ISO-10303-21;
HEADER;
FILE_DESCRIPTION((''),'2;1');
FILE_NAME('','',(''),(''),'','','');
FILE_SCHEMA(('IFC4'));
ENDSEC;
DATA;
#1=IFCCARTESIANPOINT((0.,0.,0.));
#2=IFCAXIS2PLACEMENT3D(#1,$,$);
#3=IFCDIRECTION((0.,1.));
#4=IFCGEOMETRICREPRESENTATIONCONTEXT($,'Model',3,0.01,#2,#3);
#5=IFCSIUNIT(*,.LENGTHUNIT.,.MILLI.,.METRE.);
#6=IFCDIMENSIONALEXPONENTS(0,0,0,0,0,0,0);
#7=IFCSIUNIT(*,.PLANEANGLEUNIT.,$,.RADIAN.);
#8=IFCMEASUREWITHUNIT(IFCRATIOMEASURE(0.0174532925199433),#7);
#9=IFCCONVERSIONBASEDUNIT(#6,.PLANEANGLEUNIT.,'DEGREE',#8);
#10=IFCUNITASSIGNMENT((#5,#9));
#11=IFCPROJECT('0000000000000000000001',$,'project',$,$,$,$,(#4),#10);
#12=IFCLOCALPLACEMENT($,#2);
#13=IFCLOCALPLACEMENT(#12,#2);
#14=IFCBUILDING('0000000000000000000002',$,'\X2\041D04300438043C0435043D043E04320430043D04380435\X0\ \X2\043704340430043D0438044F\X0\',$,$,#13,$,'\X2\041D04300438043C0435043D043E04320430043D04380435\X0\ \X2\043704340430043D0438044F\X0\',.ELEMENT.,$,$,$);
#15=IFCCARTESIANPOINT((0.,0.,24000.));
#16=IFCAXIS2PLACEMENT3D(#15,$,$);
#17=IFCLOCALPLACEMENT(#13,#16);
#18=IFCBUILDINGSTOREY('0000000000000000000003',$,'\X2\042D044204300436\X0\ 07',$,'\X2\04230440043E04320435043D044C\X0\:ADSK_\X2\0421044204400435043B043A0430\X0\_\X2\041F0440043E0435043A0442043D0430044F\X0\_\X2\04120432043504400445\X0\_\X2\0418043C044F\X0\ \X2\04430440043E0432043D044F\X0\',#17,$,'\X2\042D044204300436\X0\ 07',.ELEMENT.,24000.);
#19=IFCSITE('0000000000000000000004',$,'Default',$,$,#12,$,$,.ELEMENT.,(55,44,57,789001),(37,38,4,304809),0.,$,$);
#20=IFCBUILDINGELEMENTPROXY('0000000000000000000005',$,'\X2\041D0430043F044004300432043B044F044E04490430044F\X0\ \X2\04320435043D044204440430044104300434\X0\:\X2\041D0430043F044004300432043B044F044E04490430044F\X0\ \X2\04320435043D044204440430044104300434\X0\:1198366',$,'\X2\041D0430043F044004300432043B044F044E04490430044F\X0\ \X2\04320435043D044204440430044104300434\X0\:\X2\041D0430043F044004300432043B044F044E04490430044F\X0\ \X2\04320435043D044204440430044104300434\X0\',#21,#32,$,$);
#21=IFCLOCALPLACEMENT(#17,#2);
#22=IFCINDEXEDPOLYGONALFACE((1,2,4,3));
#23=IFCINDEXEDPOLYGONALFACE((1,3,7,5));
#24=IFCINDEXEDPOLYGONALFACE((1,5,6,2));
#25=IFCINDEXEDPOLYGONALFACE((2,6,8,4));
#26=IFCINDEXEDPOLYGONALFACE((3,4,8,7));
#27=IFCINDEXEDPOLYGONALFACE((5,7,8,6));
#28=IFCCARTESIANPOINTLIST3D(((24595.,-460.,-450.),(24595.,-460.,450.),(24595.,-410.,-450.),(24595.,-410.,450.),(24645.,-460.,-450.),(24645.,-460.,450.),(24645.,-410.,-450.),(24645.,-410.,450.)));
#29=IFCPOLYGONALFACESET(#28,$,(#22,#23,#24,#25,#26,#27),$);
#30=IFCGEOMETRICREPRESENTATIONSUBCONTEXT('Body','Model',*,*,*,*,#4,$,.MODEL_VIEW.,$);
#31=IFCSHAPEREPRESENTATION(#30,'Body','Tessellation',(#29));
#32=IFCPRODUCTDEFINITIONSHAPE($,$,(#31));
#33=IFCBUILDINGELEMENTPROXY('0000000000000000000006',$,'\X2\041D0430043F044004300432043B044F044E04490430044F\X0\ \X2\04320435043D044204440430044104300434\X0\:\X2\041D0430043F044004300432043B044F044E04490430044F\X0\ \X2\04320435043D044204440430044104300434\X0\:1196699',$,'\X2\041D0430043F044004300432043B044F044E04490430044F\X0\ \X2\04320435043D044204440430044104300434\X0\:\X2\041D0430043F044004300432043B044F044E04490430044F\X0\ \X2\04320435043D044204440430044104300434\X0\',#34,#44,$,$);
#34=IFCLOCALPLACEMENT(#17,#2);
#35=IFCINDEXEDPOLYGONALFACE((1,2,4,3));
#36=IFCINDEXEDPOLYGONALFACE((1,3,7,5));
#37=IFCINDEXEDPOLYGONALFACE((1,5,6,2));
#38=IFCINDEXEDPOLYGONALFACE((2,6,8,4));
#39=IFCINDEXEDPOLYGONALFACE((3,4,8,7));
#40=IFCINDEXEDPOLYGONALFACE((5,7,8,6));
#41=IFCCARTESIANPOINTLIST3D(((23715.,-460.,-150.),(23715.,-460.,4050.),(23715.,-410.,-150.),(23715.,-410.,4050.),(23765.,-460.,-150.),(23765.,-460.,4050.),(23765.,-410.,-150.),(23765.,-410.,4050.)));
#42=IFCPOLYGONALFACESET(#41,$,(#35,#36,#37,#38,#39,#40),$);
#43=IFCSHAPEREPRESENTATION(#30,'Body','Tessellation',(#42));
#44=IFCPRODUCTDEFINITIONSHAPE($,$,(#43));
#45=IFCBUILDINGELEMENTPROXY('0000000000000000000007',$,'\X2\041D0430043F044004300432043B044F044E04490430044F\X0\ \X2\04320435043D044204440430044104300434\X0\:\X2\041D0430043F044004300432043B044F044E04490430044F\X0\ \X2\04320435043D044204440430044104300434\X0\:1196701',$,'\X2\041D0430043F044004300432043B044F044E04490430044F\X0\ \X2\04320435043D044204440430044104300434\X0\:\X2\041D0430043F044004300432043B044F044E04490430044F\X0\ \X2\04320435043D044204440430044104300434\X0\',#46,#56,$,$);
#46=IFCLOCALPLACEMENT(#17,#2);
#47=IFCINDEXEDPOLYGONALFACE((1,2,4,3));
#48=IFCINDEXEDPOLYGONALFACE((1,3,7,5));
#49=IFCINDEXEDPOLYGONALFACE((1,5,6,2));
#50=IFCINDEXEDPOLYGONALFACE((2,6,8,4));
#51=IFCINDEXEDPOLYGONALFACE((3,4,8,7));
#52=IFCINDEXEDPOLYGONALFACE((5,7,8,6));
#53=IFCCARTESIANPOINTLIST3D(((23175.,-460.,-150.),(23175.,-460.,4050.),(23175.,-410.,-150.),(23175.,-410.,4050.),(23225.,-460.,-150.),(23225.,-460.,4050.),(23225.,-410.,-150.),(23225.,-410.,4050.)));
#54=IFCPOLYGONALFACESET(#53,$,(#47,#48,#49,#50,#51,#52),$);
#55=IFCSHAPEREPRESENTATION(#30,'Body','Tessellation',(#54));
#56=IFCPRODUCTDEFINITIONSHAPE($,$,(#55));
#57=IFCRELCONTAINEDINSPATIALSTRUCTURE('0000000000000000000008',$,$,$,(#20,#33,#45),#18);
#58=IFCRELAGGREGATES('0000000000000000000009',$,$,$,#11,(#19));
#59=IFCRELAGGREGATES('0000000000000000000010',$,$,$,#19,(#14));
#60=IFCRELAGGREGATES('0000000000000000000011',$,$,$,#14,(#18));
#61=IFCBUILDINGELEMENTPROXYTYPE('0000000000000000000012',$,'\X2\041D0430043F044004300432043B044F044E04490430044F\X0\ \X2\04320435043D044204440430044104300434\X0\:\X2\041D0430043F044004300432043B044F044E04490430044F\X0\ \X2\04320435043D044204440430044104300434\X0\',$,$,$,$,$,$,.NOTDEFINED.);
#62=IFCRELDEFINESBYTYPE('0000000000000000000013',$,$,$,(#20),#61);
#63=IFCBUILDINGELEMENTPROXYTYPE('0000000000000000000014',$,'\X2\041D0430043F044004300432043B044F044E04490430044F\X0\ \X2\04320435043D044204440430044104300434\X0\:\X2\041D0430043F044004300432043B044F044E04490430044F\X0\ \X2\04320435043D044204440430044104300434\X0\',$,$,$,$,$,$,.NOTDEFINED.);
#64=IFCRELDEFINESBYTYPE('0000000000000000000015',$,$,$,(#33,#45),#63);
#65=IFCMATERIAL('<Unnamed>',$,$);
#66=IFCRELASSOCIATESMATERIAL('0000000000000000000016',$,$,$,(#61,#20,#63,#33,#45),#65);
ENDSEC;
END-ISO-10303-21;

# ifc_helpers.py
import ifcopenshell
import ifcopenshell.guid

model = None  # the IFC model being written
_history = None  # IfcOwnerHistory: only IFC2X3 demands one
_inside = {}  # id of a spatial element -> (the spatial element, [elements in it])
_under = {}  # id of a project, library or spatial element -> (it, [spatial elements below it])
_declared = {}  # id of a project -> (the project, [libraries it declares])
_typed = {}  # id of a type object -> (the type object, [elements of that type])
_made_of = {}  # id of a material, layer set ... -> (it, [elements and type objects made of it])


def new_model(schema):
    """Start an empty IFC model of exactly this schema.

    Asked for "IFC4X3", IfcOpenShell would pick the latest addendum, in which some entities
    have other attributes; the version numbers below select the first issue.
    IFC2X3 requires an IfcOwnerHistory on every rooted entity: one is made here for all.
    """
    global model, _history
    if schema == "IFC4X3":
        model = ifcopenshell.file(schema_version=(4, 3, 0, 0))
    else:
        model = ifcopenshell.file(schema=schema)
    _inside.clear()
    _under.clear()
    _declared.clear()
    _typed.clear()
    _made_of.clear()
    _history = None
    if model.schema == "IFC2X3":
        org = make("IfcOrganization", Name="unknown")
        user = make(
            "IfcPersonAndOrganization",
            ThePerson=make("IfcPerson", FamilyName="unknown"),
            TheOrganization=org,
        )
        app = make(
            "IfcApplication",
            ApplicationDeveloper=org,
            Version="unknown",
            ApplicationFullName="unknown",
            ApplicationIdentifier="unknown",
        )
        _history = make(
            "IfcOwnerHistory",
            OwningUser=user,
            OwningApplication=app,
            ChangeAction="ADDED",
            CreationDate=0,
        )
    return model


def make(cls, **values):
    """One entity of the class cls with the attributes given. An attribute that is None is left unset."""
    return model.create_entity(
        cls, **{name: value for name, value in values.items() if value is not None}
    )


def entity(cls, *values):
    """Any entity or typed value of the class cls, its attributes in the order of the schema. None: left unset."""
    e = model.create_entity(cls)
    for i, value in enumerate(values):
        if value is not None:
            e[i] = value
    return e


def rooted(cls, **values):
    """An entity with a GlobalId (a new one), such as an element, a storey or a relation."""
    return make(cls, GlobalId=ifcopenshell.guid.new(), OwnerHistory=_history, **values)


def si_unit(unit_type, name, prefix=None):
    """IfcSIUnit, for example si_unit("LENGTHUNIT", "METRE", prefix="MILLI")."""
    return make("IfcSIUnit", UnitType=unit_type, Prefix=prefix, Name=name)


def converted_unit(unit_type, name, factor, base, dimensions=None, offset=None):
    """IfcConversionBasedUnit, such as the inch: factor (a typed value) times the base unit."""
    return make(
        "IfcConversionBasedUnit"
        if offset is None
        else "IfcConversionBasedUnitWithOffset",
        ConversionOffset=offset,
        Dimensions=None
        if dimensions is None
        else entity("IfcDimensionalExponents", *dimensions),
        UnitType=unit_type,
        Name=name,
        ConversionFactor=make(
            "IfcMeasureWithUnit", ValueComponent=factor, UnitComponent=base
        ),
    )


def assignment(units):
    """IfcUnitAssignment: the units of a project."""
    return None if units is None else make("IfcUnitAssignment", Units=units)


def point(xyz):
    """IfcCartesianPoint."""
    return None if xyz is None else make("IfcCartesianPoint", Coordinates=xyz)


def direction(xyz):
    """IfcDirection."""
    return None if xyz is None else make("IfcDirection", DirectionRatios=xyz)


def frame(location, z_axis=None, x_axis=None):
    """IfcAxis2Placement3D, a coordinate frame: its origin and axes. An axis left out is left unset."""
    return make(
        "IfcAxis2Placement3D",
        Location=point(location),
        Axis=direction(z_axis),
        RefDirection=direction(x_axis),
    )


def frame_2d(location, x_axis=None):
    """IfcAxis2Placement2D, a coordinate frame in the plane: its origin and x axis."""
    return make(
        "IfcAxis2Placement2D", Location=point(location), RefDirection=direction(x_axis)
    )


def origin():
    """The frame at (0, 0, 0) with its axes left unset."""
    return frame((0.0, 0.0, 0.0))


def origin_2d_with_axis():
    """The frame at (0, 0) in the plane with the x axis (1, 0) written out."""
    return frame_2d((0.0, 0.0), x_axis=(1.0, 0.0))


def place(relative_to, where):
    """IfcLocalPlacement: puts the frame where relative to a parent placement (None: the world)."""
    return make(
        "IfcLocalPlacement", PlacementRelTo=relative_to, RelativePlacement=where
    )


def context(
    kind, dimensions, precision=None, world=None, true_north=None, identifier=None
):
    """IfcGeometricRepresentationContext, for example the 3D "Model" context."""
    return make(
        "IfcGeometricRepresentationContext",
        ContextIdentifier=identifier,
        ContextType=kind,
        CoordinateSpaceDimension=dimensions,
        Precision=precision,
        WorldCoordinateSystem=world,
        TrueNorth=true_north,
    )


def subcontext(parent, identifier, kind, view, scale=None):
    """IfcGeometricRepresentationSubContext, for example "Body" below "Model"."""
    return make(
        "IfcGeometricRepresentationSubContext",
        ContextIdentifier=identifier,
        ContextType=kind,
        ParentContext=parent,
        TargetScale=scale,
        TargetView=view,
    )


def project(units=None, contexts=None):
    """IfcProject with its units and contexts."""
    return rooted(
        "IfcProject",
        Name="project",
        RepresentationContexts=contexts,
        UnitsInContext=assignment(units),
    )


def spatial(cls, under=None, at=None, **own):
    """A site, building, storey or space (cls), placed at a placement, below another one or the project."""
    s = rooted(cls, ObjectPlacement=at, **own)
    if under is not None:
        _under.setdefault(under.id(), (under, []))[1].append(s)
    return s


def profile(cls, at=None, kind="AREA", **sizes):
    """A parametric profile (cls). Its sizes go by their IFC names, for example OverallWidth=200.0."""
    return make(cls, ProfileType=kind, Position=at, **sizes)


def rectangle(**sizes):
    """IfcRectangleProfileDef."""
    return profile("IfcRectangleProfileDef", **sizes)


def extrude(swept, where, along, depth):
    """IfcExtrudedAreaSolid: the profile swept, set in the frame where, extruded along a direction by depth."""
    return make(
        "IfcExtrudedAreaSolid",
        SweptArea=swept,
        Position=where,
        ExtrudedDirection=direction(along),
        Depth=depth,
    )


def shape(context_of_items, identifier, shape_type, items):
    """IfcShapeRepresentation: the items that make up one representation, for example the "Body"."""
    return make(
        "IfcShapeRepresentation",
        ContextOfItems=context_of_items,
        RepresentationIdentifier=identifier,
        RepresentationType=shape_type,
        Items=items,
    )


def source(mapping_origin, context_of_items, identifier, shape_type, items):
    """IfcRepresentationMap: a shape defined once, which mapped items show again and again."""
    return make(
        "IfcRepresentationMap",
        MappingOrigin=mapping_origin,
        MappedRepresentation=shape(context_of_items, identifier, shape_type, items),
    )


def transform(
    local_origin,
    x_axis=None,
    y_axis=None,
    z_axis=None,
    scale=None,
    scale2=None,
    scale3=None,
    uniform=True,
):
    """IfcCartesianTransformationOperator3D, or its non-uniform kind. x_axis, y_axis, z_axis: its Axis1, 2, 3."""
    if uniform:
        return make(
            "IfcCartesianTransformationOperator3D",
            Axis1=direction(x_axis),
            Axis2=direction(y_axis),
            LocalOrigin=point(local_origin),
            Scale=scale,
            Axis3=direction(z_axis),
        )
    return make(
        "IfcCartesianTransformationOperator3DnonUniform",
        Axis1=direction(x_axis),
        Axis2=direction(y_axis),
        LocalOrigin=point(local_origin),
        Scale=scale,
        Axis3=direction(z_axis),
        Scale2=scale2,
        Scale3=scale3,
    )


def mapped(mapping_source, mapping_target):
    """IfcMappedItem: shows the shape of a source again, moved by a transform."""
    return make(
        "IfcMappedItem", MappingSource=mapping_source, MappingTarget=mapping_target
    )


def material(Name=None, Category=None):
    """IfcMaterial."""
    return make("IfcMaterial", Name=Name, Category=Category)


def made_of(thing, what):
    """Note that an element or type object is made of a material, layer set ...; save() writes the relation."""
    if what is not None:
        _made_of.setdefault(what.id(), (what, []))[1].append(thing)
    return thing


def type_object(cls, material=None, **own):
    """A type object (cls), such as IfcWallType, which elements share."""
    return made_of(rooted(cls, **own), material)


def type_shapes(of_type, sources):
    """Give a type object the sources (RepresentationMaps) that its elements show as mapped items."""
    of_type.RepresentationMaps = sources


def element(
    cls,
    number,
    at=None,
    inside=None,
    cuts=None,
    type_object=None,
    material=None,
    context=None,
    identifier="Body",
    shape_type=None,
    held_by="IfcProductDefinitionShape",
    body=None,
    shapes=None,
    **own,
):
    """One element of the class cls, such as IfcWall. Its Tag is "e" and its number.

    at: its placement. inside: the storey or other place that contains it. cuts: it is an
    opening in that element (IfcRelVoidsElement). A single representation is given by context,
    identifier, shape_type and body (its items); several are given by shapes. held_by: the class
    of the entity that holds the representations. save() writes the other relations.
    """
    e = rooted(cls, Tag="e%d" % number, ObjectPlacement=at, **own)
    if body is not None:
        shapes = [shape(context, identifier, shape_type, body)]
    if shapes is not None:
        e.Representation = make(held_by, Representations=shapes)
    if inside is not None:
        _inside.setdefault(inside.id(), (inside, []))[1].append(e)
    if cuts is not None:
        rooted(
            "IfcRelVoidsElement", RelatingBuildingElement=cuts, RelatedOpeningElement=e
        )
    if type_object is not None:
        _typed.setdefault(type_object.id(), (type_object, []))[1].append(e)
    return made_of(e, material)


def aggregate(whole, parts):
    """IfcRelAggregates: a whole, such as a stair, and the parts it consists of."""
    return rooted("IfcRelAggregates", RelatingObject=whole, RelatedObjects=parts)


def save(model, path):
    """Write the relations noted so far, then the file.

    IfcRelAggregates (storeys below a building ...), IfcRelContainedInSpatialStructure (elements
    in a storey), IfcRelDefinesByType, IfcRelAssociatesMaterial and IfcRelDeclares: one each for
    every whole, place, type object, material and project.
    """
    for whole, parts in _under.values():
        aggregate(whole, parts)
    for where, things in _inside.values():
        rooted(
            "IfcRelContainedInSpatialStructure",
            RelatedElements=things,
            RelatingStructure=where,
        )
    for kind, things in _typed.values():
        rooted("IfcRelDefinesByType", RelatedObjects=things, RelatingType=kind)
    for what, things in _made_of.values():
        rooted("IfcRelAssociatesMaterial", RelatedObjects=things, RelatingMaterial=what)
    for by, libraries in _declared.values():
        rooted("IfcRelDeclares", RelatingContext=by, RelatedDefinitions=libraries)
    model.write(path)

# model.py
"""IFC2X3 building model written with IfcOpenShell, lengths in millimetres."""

from ifc_helpers import new_model, entity, si_unit, converted_unit, direction, frame, origin, origin_2d_with_axis, place, context, subcontext, project, spatial, rectangle, extrude, source, transform, mapped, material, type_object, type_shapes, element, save


model = new_model("IFC2X3")

# Units and contexts
model_context = context("Model", 3, precision=0.01, world=origin(), true_north=direction((0.0, 1.0)))
body_context = subcontext(model_context, "Body", "Model", "MODEL_VIEW")
ifc_project = project(units=[si_unit("LENGTHUNIT", "METRE", prefix="MILLI"), converted_unit("PLANEANGLEUNIT", "DEGREE", entity("IfcRatioMeasure", 0.0174532925199433), si_unit("PLANEANGLEUNIT", "RADIAN"), dimensions=[0, 0, 0, 0, 0, 0, 0])], contexts=[model_context])

# Site, building, storey
site_placement = place(None, origin())
site = spatial("IfcSite", under=ifc_project, at=site_placement, Name="Default", CompositionType="ELEMENT", RefLatitude=(55, 44, 57, 789001), RefLongitude=(37, 38, 4, 304809), RefElevation=0.0)
building_placement = place(site_placement, origin())
building = spatial("IfcBuilding", under=site, at=building_placement, Name="Наименование здания", LongName="Наименование здания", CompositionType="ELEMENT")
storey_placement = place(building_placement, frame((0.0, 0.0, 24000.0)))
storey = spatial("IfcBuildingStorey", under=building, at=storey_placement, Name="Этаж 07", ObjectType="Уровень:ADSK_Стрелка_Проектная_Вверх_Имя уровня", LongName="Этаж 07", CompositionType="ELEMENT", Elevation=24000.0)

# Building element proxies
ifc_material_1 = material(Name="<Unnamed>")
building_element_proxy_type_1 = type_object("IfcBuildingElementProxyType", Name="Направляющая вентфасад:Направляющая вентфасад", PredefinedType="NOTDEFINED", material=ifc_material_1)
shared_shape_1 = source(origin(), body_context, "Body", "SweptSolid", [
    extrude(rectangle(XDim=50.0, YDim=50.0, at=origin_2d_with_axis()), frame((25.0, -25.0, 0.0), z_axis=(0.0, 0.0, 1.0), x_axis=(-1.0, 0.0, 0.0)), (0.0, 0.0, 1.0), 900.0),
])
type_shapes(building_element_proxy_type_1, [shared_shape_1])
proxy_1_placement = place(storey_placement, frame((24595.0, -410.0, -450.0)))
element("IfcBuildingElementProxy", 1, at=proxy_1_placement, inside=storey, type_object=building_element_proxy_type_1, material=ifc_material_1, Name="Направляющая вентфасад:Направляющая вентфасад:1198366", ObjectType="Направляющая вентфасад:Направляющая вентфасад", context=body_context, shape_type="MappedRepresentation", body=[
    mapped(shared_shape_1, transform((0.0, 0.0, 0.0), scale=1.0)),
])
building_element_proxy_type_2 = type_object("IfcBuildingElementProxyType", Name="Направляющая вентфасад:Направляющая вентфасад", PredefinedType="NOTDEFINED", material=ifc_material_1)
shared_shape_2 = source(origin(), body_context, "Body", "SweptSolid", [
    extrude(rectangle(XDim=50.0, YDim=50.0, at=origin_2d_with_axis()), frame((25.0, -25.0, 0.0), z_axis=(0.0, 0.0, 1.0), x_axis=(-1.0, 0.0, 0.0)), (0.0, 0.0, 1.0), 4200.0),
])
type_shapes(building_element_proxy_type_2, [shared_shape_2])
for number, where, name in (
    (2, (23715.0, -410.0, -150.0), "Направляющая вентфасад:Направляющая вентфасад:1196699"),
    (3, (23175.0, -410.0, -150.0), "Направляющая вентфасад:Направляющая вентфасад:1196701"),
):
    element("IfcBuildingElementProxy", number, at=place(storey_placement, frame(where)), inside=storey, type_object=building_element_proxy_type_2, material=ifc_material_1, Name=name, ObjectType="Направляющая вентфасад:Направляющая вентфасад", context=body_context, shape_type="MappedRepresentation", body=[
        mapped(shared_shape_2, transform((0.0, 0.0, 0.0), scale=1.0)),
    ])

save(model, "model.ifc")
